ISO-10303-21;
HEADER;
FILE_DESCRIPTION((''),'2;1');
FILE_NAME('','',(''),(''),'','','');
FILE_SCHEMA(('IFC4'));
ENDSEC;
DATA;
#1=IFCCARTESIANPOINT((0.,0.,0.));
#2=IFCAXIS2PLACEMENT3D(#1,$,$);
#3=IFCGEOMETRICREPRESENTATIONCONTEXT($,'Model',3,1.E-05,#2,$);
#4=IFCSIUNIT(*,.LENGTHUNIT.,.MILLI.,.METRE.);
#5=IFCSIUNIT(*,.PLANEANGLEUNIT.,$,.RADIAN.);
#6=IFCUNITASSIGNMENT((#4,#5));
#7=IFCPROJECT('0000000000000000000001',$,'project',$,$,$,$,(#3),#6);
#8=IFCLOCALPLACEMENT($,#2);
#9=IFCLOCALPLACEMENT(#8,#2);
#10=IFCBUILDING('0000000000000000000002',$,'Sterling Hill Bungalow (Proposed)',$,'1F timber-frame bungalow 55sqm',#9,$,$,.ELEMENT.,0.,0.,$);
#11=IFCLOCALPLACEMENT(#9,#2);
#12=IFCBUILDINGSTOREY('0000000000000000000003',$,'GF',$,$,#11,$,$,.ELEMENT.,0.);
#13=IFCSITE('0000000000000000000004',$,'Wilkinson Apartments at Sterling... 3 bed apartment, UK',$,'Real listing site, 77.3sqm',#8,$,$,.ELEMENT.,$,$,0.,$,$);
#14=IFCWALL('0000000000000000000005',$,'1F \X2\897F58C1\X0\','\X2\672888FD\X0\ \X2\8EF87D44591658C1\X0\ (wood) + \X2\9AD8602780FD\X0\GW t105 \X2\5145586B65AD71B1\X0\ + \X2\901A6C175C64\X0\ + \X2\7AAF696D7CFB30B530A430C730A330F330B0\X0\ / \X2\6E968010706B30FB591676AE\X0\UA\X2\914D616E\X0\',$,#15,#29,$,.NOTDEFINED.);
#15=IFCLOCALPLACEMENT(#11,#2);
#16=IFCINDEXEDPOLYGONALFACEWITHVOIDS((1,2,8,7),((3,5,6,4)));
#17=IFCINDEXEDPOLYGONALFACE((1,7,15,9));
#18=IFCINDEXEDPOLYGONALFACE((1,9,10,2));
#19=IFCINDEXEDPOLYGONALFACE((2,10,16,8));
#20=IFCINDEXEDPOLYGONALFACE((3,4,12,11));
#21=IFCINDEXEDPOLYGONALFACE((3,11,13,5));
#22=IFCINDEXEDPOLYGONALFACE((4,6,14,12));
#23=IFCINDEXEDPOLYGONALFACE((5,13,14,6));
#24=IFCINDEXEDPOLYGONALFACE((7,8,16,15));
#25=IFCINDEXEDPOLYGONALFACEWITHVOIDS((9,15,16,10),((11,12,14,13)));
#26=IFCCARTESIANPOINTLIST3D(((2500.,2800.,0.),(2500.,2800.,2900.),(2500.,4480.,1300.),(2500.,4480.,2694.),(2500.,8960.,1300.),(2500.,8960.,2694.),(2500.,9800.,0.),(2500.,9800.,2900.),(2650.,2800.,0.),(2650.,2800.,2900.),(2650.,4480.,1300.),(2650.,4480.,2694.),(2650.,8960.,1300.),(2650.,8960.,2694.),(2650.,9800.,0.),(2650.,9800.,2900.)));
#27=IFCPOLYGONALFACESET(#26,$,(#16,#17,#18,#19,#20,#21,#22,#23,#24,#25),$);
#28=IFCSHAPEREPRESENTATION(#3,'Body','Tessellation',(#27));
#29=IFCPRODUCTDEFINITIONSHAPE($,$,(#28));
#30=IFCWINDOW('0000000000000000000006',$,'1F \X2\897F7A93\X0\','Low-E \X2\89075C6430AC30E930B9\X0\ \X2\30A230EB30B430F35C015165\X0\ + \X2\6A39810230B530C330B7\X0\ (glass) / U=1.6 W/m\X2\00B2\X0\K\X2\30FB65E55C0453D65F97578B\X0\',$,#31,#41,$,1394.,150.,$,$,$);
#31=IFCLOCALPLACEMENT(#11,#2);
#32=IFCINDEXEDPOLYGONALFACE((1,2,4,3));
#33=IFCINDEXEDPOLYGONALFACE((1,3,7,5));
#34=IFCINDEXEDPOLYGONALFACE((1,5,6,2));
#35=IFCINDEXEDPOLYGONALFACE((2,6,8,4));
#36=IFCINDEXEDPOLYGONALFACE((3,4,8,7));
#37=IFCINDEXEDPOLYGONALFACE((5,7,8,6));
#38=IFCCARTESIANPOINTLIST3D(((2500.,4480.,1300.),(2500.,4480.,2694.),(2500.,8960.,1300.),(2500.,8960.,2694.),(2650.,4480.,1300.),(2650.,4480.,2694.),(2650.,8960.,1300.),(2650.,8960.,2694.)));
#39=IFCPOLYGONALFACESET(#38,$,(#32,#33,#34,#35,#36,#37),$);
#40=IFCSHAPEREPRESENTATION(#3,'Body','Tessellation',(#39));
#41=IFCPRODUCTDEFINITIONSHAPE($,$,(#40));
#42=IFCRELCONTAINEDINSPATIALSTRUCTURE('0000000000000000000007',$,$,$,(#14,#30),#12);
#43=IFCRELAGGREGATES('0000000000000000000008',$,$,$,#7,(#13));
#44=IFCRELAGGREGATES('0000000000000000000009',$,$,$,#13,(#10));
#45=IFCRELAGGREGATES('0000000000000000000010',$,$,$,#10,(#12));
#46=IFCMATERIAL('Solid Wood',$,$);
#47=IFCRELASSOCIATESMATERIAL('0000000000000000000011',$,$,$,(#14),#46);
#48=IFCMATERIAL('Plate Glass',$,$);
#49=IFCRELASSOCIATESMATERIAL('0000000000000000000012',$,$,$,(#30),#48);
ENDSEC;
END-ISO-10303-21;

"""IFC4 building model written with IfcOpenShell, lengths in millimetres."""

from ifc_helpers import new_model, si_unit, frame, frame_2d, origin, place, context, project, spatial, rectangle, extrude, material, element, fill, save


model = new_model("IFC4")

# Units and contexts
model_context = context("Model", 3, precision=1e-05, world=origin())
ifc_project = project(units=[si_unit("LENGTHUNIT", "METRE", prefix="MILLI"), si_unit("PLANEANGLEUNIT", "RADIAN")], contexts=[model_context])

# Site, building, storey
site_placement = place(None, origin())
site = spatial("IfcSite", under=ifc_project, at=site_placement, Name="Wilkinson Apartments at Sterling... 3 bed apartment, UK", ObjectType="Real listing site, 77.3sqm", CompositionType="ELEMENT", RefElevation=0.0)
building_placement = place(site_placement, origin())
building = spatial("IfcBuilding", under=site, at=building_placement, Name="Sterling Hill Bungalow (Proposed)", ObjectType="1F timber-frame bungalow 55sqm", CompositionType="ELEMENT", ElevationOfRefHeight=0.0, ElevationOfTerrain=0.0)
storey_placement = place(building_placement, origin())
storey = spatial("IfcBuildingStorey", under=building, at=storey_placement, Name="GF", CompositionType="ELEMENT", Elevation=0.0)

# Shared definitions
ifc_material_1 = material(Name="Solid Wood")

# Shared definitions
ifc_material_2 = material(Name="Plate Glass")

# Wall, opening, window
wall_1_placement = place(storey_placement, frame((1250.0, 1400.0, 0.0)))
wall_1 = element("IfcWall", 1, at=wall_1_placement, inside=storey, material=ifc_material_1, Name="1F 西壁", Description="木製 軸組外壁 (wood) + 高性能GW t105 充填断熱 + 通気層 + 窯業系サイディング / 準耐火・外皮UA配慮", PredefinedType="NOTDEFINED", context=model_context, shape_type="SweptSolid", body=[
    extrude(rectangle(XDim=150.0, YDim=7000.0, at=frame_2d((75.0, 3500.0))), frame((1250.0, 1400.0, 0.0)), (0.0, 0.0, 1.0), 2900.0),
])
opening_1_placement = place(storey_placement, frame((1250.0, 2240.0, 650.0)))
opening_1 = element("IfcOpeningElement", 2, at=opening_1_placement, cuts=wall_1, PredefinedType="NOTDEFINED", context=model_context, shape_type="SweptSolid", body=[
    extrude(rectangle(XDim=150.0, YDim=4480.0, at=frame_2d((75.0, 2240.0))), frame((1250.0, 2240.0, 650.0)), (0.0, 0.0, 1.0), 1394.0),
])
window_1_placement = place(storey_placement, frame((1250.0, 2240.0, 650.0)))
window_1 = element("IfcWindow", 3, at=window_1_placement, inside=storey, material=ifc_material_2, Name="1F 西窓", Description="Low-E 複層ガラス アルゴン封入 + 樹脂サッシ (glass) / U=1.6 W/m²K・日射取得型", OverallHeight=1394.0, OverallWidth=150.0, context=model_context, shape_type="SweptSolid", body=[
    extrude(rectangle(XDim=150.0, YDim=4480.0, at=frame_2d((75.0, 2240.0))), frame((1250.0, 2240.0, 650.0)), (0.0, 0.0, 1.0), 1394.0),
])
fill(opening_1, window_1)

save(model, "model.ifc")
